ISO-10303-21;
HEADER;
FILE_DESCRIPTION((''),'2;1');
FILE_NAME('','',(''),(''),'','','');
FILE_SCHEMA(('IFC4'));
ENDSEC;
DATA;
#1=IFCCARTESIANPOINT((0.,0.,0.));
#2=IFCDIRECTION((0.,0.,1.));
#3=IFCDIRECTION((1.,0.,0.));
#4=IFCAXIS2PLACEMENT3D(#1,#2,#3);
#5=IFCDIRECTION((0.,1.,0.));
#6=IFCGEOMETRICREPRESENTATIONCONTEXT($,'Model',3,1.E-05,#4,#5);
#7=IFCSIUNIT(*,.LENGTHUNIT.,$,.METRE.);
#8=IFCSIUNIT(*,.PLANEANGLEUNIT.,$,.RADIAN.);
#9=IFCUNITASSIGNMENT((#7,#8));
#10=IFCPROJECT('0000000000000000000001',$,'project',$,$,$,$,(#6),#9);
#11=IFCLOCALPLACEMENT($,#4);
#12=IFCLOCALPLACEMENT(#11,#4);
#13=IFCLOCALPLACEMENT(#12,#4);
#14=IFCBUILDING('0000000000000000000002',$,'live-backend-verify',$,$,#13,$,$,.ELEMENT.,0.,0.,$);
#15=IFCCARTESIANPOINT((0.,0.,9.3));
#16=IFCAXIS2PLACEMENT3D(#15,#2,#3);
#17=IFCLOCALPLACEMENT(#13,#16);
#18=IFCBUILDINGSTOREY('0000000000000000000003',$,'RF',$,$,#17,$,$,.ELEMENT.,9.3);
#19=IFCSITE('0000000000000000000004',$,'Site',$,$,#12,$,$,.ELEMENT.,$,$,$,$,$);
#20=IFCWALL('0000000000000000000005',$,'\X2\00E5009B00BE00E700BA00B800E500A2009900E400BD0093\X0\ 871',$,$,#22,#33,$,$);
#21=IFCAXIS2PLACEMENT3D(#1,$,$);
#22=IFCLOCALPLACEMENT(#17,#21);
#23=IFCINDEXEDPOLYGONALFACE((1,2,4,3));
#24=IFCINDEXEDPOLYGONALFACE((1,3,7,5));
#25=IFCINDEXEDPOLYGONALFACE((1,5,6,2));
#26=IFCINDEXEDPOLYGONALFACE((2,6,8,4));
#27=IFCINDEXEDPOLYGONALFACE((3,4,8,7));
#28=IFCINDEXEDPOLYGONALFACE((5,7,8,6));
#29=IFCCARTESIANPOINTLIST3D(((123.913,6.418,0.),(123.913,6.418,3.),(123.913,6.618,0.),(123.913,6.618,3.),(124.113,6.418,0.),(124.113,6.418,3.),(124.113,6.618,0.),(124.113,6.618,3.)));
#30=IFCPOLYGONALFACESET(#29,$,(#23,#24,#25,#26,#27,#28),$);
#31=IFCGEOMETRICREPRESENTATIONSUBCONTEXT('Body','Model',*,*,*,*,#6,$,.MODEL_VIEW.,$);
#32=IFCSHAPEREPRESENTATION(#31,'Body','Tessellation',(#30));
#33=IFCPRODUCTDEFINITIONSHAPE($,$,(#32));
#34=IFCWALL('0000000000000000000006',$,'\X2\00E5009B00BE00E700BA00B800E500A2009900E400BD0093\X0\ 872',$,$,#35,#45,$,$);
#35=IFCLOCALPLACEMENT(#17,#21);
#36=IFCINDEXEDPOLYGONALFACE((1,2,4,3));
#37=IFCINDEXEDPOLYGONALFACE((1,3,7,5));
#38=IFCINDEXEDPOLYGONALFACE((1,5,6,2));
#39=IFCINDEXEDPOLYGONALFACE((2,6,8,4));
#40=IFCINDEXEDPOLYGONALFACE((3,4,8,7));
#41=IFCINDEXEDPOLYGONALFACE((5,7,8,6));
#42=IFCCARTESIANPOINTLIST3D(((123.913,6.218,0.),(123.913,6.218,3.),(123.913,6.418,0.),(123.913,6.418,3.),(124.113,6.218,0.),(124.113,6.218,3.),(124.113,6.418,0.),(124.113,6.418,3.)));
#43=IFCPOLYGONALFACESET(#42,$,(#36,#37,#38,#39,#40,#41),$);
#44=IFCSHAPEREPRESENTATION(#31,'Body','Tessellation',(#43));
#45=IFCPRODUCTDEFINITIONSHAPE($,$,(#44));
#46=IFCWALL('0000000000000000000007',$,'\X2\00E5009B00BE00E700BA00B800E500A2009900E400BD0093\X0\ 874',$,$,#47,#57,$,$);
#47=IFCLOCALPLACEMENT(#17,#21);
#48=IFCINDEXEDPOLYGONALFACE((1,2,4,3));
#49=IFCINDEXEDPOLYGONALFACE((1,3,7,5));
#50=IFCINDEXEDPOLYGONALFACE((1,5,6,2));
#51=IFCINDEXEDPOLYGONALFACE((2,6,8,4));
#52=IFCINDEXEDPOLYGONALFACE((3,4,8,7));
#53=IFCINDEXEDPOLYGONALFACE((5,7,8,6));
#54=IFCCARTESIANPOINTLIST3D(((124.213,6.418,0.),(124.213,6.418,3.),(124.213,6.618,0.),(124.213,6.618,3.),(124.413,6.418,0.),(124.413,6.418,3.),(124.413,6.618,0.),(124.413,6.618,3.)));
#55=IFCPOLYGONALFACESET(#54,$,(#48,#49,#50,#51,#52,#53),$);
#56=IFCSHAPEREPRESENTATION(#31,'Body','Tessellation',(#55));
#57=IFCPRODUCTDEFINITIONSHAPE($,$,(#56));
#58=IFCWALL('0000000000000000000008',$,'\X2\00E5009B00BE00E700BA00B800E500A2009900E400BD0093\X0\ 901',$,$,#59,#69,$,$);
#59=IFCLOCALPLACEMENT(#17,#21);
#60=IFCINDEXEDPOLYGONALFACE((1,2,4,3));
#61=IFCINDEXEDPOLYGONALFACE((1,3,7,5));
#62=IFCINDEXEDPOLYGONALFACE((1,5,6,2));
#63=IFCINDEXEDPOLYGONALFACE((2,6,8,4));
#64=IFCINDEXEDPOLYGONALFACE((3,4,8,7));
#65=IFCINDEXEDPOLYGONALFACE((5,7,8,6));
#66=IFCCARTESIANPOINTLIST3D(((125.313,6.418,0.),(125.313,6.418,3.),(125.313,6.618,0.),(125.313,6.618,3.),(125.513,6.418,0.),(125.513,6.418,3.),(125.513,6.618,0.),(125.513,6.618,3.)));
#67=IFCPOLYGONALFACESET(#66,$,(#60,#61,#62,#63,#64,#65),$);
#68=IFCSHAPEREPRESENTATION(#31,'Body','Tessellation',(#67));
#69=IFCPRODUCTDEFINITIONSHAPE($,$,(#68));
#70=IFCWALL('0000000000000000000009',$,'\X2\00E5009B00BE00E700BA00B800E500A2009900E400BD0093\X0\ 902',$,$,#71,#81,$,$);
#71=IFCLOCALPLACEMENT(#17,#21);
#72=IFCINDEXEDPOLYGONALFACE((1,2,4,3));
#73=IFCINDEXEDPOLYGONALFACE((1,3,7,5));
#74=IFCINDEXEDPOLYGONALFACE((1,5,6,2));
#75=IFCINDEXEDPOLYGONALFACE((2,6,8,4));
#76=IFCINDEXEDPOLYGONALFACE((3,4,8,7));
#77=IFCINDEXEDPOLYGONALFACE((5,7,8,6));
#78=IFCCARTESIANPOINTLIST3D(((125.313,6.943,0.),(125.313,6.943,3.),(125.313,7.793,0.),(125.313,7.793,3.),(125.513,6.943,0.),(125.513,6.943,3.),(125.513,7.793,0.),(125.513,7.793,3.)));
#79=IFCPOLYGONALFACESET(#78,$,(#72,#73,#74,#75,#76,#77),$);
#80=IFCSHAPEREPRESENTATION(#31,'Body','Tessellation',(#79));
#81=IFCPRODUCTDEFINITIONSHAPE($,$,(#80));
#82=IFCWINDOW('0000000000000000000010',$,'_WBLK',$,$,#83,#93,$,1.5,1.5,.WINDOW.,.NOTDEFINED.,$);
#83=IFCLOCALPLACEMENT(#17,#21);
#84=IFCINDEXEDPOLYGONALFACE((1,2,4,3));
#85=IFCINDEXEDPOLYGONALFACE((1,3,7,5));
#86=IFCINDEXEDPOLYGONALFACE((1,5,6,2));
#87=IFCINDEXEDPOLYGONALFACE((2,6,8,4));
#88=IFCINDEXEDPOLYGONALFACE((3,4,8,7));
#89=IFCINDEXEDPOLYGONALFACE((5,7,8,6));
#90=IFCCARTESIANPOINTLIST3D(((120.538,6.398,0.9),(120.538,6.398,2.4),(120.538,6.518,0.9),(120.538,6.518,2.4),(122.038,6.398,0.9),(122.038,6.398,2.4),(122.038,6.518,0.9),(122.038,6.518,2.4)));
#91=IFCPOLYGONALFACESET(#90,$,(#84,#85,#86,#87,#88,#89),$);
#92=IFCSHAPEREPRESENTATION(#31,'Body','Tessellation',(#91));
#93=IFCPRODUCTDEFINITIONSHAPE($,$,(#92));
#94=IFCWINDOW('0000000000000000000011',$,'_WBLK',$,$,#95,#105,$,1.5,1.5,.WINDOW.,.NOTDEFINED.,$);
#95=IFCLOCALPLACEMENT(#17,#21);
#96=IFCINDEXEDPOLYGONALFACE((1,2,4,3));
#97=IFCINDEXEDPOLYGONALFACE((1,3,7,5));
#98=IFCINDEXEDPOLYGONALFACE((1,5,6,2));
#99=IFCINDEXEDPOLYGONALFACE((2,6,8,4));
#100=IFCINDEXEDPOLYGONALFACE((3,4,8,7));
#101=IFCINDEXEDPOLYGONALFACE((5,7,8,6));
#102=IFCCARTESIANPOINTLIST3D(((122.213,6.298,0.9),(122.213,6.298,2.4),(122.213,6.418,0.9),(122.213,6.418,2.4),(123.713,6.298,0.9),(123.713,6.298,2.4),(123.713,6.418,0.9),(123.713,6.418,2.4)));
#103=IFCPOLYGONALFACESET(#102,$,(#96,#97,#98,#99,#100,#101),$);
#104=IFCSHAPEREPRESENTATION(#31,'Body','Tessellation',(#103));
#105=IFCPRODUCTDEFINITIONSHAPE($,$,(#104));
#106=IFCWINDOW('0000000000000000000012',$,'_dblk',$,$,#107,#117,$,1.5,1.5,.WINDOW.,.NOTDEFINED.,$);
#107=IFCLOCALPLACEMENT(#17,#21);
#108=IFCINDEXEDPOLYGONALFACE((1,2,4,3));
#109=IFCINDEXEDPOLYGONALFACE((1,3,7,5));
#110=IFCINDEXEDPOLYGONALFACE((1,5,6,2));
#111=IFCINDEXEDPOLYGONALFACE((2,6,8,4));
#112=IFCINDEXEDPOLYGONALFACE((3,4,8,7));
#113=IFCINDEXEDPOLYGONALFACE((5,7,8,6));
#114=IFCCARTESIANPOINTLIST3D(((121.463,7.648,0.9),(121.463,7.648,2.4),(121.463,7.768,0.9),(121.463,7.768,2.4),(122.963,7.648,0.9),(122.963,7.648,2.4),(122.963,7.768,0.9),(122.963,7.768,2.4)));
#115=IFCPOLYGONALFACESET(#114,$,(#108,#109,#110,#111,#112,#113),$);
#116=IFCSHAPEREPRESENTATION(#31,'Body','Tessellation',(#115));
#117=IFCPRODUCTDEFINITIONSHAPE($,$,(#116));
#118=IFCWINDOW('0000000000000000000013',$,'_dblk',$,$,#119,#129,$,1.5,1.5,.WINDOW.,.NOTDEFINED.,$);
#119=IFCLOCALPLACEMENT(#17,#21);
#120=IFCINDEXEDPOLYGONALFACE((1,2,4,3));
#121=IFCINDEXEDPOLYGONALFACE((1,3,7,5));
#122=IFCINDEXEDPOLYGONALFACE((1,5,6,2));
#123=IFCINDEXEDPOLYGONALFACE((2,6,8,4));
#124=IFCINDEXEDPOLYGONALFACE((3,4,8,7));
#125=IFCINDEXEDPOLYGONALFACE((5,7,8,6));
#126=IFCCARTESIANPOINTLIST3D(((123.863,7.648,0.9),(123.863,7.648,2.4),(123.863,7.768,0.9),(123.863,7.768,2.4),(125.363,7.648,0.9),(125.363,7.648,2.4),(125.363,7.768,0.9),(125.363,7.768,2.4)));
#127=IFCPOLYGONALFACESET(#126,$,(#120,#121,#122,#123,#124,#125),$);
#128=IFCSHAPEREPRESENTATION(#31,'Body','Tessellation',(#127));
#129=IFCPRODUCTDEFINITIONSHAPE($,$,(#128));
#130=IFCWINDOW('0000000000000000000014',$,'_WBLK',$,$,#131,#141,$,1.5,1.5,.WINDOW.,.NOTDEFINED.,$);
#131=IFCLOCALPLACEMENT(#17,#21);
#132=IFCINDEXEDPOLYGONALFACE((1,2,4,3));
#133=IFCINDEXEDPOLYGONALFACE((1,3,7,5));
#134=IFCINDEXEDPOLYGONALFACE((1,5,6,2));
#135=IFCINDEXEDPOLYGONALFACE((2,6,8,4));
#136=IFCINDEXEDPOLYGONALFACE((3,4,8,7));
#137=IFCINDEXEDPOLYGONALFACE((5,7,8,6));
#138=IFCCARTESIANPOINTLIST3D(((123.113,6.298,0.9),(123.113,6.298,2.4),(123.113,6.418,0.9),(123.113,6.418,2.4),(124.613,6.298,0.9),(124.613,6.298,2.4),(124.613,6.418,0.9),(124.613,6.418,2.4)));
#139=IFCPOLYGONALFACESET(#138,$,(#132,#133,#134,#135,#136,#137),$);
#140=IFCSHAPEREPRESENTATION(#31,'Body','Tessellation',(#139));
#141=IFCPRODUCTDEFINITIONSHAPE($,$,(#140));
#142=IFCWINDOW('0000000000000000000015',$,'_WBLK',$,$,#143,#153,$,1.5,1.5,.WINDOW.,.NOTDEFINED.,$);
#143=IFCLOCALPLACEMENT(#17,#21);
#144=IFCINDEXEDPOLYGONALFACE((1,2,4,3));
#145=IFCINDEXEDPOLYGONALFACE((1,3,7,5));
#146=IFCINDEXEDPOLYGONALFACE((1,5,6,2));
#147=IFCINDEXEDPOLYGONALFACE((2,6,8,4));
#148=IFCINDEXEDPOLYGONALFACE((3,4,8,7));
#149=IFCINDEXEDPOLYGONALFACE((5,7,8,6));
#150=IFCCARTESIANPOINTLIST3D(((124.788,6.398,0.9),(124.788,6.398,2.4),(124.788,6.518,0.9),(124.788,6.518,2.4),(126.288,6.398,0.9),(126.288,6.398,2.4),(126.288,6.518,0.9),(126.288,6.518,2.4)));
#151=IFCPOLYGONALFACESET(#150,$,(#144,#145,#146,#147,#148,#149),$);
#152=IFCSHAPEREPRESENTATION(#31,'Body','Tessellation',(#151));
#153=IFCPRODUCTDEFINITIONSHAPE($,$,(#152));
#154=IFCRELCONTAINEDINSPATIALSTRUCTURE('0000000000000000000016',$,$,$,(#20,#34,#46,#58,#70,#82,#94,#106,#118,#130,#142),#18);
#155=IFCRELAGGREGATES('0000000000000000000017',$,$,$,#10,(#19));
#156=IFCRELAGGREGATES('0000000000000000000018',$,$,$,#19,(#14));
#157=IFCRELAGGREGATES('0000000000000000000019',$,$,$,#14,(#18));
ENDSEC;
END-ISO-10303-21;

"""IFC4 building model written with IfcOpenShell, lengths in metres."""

from ifc_helpers import new_model, si_unit, direction, frame, frame_2d, origin_with_axes, place, context, subcontext, project, spatial, rectangle, extrude, element, save


model = new_model("IFC4")

# Units and contexts
model_context = context("Model", 3, precision=1e-05, world=origin_with_axes(), true_north=direction((0.0, 1.0, 0.0)))
body_context = subcontext(model_context, "Body", "Model", "MODEL_VIEW")
ifc_project = project(units=[si_unit("LENGTHUNIT", "METRE"), si_unit("PLANEANGLEUNIT", "RADIAN")], contexts=[model_context])

# Site, building, storey
placement = place(None, origin_with_axes())
site_placement = place(placement, origin_with_axes())
site = spatial("IfcSite", under=ifc_project, at=site_placement, Name="Site", CompositionType="ELEMENT")
building_placement = place(site_placement, origin_with_axes())
building = spatial("IfcBuilding", under=site, at=building_placement, Name="live-backend-verify", CompositionType="ELEMENT", ElevationOfRefHeight=0.0, ElevationOfTerrain=0.0)
storey_placement = place(building_placement, frame((0.0, 0.0, 9.3), z_axis=(0.0, 0.0, 1.0), x_axis=(1.0, 0.0, 0.0)))
storey = spatial("IfcBuildingStorey", under=building, at=storey_placement, Name="RF", CompositionType="ELEMENT", Elevation=9.3)

# Walls
for number, where, z_axis, x_axis, name in (
    (1, (124.013, 6.518, 0.0), (0.0, 0.0, 1.0), (1.0, 0.0, 0.0), "å\u009b¾çº¸å¢\u0099ä½\u0093 871"),
    (2, (124.013, 6.318, 0.0), (0.0, 0.0, 1.0), (1.0, 0.0, 0.0), "å\u009b¾çº¸å¢\u0099ä½\u0093 872"),
    (3, (124.313, 6.518, 0.0), (0.0, 0.0, 1.0), (-1.0, 0.0, 0.0), "å\u009b¾çº¸å¢\u0099ä½\u0093 874"),
    (4, (125.413, 6.518, 0.0), (0.0, 0.0, 1.0), (0.0, -1.0, 0.0), "å\u009b¾çº¸å¢\u0099ä½\u0093 901"),
):
    element("IfcWall", number, at=place(storey_placement, frame(where, z_axis=z_axis, x_axis=x_axis)), inside=storey, Name=name, context=body_context, shape_type="SweptSolid", body=[
        extrude(rectangle(XDim=0.2, YDim=0.2, at=frame_2d((0.0, 0.0), x_axis=(1.0, 0.0, 0.0))), frame((0.0, 0.0, 0.0), z_axis=(0.0, 0.0, 1.0)), (0.0, 0.0, 1.0), 3.0),
    ])
wall_1_placement = place(storey_placement, frame((125.413, 7.368, 0.0), z_axis=(0.0, 0.0, 1.0), x_axis=(0.0, -1.0, 0.0)))
element("IfcWall", 5, at=wall_1_placement, inside=storey, Name="å\u009b¾çº¸å¢\u0099ä½\u0093 902", context=body_context, shape_type="SweptSolid", body=[
    extrude(rectangle(XDim=0.85, YDim=0.2, at=frame_2d((0.0, 0.0), x_axis=(1.0, 0.0, 0.0))), frame((0.0, 0.0, 0.0), z_axis=(0.0, 0.0, 1.0)), (0.0, 0.0, 1.0), 3.0),
])

# Windows
for number, where, z_axis, x_axis, name in (
    (6, (121.288, 6.458, 0.9), (0.0, 0.0, 1.0), (1.0, 0.0, 0.0), "_WBLK"),
    (7, (122.963, 6.358, 0.9), (0.0, 0.0, 1.0), (1.0, 0.0, 0.0), "_WBLK"),
    (8, (122.213, 7.708, 0.9), (0.0, 0.0, 1.0), (1.0, 0.0, 0.0), "_dblk"),
    (9, (124.613, 7.708, 0.9), (0.0, 0.0, 1.0), (1.0, 0.0, 0.0), "_dblk"),
    (10, (123.863, 6.358, 0.9), (0.0, 0.0, 1.0), (1.0, 0.0, 0.0), "_WBLK"),
    (11, (125.538, 6.458, 0.9), (0.0, 0.0, 1.0), (1.0, 0.0, 0.0), "_WBLK"),
):
    element("IfcWindow", number, at=place(storey_placement, frame(where, z_axis=z_axis, x_axis=x_axis)), inside=storey, Name=name, OverallHeight=1.5, OverallWidth=1.5, PartitioningType="NOTDEFINED", PredefinedType="WINDOW", context=body_context, shape_type="SweptSolid", body=[
        extrude(rectangle(XDim=1.5, YDim=0.12, at=frame_2d((0.0, 0.0), x_axis=(1.0, 0.0, 0.0))), frame((0.0, 0.0, 0.0), z_axis=(0.0, 0.0, 1.0)), (0.0, 0.0, 1.0), 1.5),
    ])

save(model, "model.ifc")
